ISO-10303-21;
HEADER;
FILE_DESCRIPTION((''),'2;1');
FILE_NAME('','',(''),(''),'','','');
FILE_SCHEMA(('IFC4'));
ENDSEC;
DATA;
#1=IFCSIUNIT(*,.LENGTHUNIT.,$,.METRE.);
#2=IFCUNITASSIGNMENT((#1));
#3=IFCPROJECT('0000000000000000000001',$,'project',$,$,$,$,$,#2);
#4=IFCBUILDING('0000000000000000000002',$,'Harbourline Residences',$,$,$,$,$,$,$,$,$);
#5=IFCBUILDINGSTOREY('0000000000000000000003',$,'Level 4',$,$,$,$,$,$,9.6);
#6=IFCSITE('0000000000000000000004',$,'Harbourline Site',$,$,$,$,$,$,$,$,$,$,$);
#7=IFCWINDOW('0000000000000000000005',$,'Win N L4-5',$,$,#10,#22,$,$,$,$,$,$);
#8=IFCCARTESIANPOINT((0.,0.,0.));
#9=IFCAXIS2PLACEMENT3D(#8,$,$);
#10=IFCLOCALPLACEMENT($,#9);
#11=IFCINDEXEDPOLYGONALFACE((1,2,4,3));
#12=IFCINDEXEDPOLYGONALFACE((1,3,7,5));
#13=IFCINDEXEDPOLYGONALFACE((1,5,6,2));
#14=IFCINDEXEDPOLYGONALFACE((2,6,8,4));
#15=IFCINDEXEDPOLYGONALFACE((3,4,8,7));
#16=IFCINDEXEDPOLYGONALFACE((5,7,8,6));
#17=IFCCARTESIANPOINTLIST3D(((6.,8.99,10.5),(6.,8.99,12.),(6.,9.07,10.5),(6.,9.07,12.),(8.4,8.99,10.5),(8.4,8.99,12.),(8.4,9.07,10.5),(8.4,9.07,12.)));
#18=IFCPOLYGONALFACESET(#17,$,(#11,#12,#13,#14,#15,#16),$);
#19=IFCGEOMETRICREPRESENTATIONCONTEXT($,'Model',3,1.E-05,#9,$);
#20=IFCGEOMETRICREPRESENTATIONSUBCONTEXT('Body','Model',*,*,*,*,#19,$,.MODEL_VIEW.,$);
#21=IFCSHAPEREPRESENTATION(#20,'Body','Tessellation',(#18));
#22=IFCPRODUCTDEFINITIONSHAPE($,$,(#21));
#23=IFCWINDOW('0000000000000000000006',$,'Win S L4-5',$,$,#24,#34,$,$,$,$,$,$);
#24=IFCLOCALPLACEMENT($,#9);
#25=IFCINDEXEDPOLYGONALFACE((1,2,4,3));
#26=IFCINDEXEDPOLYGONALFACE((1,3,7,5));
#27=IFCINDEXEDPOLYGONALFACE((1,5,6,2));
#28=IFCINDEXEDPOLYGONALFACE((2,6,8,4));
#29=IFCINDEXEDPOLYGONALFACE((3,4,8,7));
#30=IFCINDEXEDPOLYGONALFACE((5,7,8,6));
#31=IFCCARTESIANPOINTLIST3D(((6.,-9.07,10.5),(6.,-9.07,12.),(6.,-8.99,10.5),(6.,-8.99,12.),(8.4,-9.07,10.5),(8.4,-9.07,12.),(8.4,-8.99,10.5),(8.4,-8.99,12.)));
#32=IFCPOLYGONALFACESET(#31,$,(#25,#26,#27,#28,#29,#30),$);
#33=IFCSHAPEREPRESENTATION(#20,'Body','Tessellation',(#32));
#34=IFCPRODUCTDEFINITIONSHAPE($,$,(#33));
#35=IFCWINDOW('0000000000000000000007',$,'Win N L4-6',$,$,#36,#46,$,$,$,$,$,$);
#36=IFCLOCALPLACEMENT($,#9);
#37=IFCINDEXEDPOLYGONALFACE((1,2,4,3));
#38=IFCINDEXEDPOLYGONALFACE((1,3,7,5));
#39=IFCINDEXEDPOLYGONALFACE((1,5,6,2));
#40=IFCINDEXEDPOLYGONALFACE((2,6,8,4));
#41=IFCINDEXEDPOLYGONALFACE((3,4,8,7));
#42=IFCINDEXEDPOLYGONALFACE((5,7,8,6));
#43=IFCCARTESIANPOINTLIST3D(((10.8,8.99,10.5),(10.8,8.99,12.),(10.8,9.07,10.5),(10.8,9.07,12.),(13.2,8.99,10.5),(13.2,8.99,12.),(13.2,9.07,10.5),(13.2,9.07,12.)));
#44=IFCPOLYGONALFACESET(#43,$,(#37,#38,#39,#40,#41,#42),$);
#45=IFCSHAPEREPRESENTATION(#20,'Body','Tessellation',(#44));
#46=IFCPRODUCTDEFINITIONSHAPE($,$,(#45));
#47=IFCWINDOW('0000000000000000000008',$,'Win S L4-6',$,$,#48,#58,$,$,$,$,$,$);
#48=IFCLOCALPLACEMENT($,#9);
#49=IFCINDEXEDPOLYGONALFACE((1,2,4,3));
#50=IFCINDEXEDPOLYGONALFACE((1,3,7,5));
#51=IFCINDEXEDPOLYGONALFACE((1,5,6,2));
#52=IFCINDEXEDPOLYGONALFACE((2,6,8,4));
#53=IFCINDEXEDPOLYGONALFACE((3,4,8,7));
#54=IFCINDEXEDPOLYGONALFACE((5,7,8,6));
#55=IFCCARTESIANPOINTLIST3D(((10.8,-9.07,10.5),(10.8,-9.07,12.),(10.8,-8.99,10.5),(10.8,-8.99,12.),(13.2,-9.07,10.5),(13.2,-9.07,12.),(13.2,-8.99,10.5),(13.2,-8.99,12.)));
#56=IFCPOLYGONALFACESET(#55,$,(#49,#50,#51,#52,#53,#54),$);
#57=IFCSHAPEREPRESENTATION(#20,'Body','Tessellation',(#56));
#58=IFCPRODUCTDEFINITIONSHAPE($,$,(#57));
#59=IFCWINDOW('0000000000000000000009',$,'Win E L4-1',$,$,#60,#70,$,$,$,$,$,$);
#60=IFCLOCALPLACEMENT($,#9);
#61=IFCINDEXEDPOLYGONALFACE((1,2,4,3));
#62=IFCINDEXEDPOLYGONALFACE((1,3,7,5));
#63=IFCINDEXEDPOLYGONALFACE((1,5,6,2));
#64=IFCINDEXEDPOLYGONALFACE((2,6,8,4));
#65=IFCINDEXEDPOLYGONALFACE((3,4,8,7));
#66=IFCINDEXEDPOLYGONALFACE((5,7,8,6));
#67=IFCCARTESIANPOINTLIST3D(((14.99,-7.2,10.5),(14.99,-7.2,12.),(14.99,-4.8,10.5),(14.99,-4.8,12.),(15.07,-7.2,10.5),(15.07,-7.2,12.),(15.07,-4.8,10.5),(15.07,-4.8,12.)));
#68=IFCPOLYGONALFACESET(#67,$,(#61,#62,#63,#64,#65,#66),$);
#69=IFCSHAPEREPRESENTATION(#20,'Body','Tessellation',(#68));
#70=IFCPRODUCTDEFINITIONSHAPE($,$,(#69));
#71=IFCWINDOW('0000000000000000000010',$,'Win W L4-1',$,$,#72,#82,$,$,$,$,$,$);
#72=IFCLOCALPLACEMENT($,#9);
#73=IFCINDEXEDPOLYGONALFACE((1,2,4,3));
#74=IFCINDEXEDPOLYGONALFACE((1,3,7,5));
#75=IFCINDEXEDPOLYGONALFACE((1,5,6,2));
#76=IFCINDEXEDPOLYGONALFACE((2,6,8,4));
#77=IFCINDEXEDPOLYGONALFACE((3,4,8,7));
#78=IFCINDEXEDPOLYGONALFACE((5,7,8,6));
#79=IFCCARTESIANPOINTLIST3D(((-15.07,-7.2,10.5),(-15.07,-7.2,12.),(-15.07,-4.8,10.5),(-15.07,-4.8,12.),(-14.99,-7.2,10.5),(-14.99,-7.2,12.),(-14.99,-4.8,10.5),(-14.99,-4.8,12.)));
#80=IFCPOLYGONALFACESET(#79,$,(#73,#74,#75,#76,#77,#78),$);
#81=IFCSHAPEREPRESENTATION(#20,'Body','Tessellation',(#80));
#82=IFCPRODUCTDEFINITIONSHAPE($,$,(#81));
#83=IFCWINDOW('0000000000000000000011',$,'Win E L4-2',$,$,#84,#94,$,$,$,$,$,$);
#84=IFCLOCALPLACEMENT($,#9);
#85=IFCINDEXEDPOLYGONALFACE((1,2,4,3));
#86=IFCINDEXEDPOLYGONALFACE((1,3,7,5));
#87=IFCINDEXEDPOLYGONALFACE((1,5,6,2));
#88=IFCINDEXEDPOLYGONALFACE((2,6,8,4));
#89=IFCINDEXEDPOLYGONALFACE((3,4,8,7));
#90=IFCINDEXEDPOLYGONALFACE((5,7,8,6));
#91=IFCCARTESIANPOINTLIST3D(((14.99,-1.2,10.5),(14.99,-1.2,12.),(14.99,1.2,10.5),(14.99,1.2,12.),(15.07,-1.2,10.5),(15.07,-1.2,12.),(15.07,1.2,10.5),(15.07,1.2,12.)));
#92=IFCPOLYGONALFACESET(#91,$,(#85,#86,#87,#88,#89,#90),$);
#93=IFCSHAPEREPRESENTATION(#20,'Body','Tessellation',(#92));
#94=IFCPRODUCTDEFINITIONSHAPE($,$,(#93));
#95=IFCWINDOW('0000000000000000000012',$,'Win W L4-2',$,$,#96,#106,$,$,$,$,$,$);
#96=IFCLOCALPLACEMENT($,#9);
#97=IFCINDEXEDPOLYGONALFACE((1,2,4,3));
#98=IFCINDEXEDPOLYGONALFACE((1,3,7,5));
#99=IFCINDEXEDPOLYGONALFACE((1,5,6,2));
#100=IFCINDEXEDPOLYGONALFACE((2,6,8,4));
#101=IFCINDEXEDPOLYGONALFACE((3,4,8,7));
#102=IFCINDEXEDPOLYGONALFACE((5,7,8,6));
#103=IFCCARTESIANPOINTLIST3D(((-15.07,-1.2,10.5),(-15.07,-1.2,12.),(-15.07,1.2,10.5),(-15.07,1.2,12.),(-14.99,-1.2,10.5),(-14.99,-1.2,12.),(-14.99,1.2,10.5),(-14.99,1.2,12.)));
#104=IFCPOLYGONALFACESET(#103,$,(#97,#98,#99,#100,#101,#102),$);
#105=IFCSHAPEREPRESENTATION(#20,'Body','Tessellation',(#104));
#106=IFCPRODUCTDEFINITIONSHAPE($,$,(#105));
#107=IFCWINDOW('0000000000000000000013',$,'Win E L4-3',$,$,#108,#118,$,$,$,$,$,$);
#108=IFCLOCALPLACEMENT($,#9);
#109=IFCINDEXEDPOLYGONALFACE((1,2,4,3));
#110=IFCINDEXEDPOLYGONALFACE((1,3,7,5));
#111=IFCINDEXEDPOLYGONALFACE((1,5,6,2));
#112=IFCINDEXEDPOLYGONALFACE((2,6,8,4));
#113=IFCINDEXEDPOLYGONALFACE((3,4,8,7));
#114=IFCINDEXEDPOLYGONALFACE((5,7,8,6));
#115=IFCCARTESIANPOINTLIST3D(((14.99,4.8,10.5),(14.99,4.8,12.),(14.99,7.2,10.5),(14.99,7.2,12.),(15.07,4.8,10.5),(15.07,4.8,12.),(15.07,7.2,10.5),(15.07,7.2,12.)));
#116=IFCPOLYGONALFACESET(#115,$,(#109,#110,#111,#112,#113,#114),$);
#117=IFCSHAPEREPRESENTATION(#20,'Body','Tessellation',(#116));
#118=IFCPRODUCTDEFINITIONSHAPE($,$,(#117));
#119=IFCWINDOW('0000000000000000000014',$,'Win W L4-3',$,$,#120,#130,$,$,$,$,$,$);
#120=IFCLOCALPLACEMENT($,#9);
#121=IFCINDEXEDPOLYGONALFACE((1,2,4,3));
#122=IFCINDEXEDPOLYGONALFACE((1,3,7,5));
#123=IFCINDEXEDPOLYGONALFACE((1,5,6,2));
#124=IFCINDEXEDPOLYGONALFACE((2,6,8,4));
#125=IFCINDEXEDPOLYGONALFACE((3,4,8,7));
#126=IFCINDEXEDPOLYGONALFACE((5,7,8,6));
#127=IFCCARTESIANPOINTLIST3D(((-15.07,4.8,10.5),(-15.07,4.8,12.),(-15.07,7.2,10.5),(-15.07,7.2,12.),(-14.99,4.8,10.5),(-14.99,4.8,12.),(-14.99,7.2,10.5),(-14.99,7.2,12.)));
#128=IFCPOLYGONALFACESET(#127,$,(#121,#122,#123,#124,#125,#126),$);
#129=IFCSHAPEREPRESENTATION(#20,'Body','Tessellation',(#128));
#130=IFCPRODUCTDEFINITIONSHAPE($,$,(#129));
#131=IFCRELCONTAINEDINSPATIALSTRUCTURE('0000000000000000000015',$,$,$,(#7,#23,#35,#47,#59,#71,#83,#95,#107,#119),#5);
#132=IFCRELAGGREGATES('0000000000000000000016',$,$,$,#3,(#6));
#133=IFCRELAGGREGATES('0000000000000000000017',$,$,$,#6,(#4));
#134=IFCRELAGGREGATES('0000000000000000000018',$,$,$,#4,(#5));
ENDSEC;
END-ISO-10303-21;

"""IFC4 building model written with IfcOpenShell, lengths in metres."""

from ifc_helpers import new_model, si_unit, frame, frame_2d, origin, context, subcontext, project, spatial, rectangle, extrude, element, save


model = new_model("IFC4")

# Units and contexts
model_context = context("Model", 3, precision=1e-05, world=origin())
body_context = subcontext(model_context, "Body", "Model", "MODEL_VIEW")
ifc_project = project(units=[si_unit("LENGTHUNIT", "METRE")])

# Site, building, storey
site = spatial("IfcSite", under=ifc_project, Name="Harbourline Site")
building = spatial("IfcBuilding", under=site, Name="Harbourline Residences")
storey = spatial("IfcBuildingStorey", under=building, Name="Level 4", Elevation=9.6)

# Windows
element("IfcWindow", 1, inside=storey, Name="Win N L4-5", context=body_context, shape_type="SweptSolid", body=[
    extrude(rectangle(XDim=2.4, YDim=0.08, at=frame_2d((7.2, 9.03))), frame((0.0, 0.0, 10.5)), (0.0, 0.0, 1.0), 1.5),
])
element("IfcWindow", 2, inside=storey, Name="Win S L4-5", context=body_context, shape_type="SweptSolid", body=[
    extrude(rectangle(XDim=2.4, YDim=0.08, at=frame_2d((7.2, -9.03))), frame((0.0, 0.0, 10.5)), (0.0, 0.0, 1.0), 1.5),
])
element("IfcWindow", 3, inside=storey, Name="Win N L4-6", context=body_context, shape_type="SweptSolid", body=[
    extrude(rectangle(XDim=2.4, YDim=0.08, at=frame_2d((12.0, 9.03))), frame((0.0, 0.0, 10.5)), (0.0, 0.0, 1.0), 1.5),
])
element("IfcWindow", 4, inside=storey, Name="Win S L4-6", context=body_context, shape_type="SweptSolid", body=[
    extrude(rectangle(XDim=2.4, YDim=0.08, at=frame_2d((12.0, -9.03))), frame((0.0, 0.0, 10.5)), (0.0, 0.0, 1.0), 1.5),
])
element("IfcWindow", 5, inside=storey, Name="Win E L4-1", context=body_context, shape_type="SweptSolid", body=[
    extrude(rectangle(XDim=0.08, YDim=2.4, at=frame_2d((15.03, -6.0))), frame((0.0, 0.0, 10.5)), (0.0, 0.0, 1.0), 1.5),
])
element("IfcWindow", 6, inside=storey, Name="Win W L4-1", context=body_context, shape_type="SweptSolid", body=[
    extrude(rectangle(XDim=0.08, YDim=2.4, at=frame_2d((-15.03, -6.0))), frame((0.0, 0.0, 10.5)), (0.0, 0.0, 1.0), 1.5),
])
element("IfcWindow", 7, inside=storey, Name="Win E L4-2", context=body_context, shape_type="SweptSolid", body=[
    extrude(rectangle(XDim=0.08, YDim=2.4, at=frame_2d((15.03, 0.0))), frame((0.0, 0.0, 10.5)), (0.0, 0.0, 1.0), 1.5),
])
element("IfcWindow", 8, inside=storey, Name="Win W L4-2", context=body_context, shape_type="SweptSolid", body=[
    extrude(rectangle(XDim=0.08, YDim=2.4, at=frame_2d((-15.03, 0.0))), frame((0.0, 0.0, 10.5)), (0.0, 0.0, 1.0), 1.5),
])
element("IfcWindow", 9, inside=storey, Name="Win E L4-3", context=body_context, shape_type="SweptSolid", body=[
    extrude(rectangle(XDim=0.08, YDim=2.4, at=frame_2d((15.03, 6.0))), frame((0.0, 0.0, 10.5)), (0.0, 0.0, 1.0), 1.5),
])
element("IfcWindow", 10, inside=storey, Name="Win W L4-3", context=body_context, shape_type="SweptSolid", body=[
    extrude(rectangle(XDim=0.08, YDim=2.4, at=frame_2d((-15.03, 6.0))), frame((0.0, 0.0, 10.5)), (0.0, 0.0, 1.0), 1.5),
])

save(model, "model.ifc")
